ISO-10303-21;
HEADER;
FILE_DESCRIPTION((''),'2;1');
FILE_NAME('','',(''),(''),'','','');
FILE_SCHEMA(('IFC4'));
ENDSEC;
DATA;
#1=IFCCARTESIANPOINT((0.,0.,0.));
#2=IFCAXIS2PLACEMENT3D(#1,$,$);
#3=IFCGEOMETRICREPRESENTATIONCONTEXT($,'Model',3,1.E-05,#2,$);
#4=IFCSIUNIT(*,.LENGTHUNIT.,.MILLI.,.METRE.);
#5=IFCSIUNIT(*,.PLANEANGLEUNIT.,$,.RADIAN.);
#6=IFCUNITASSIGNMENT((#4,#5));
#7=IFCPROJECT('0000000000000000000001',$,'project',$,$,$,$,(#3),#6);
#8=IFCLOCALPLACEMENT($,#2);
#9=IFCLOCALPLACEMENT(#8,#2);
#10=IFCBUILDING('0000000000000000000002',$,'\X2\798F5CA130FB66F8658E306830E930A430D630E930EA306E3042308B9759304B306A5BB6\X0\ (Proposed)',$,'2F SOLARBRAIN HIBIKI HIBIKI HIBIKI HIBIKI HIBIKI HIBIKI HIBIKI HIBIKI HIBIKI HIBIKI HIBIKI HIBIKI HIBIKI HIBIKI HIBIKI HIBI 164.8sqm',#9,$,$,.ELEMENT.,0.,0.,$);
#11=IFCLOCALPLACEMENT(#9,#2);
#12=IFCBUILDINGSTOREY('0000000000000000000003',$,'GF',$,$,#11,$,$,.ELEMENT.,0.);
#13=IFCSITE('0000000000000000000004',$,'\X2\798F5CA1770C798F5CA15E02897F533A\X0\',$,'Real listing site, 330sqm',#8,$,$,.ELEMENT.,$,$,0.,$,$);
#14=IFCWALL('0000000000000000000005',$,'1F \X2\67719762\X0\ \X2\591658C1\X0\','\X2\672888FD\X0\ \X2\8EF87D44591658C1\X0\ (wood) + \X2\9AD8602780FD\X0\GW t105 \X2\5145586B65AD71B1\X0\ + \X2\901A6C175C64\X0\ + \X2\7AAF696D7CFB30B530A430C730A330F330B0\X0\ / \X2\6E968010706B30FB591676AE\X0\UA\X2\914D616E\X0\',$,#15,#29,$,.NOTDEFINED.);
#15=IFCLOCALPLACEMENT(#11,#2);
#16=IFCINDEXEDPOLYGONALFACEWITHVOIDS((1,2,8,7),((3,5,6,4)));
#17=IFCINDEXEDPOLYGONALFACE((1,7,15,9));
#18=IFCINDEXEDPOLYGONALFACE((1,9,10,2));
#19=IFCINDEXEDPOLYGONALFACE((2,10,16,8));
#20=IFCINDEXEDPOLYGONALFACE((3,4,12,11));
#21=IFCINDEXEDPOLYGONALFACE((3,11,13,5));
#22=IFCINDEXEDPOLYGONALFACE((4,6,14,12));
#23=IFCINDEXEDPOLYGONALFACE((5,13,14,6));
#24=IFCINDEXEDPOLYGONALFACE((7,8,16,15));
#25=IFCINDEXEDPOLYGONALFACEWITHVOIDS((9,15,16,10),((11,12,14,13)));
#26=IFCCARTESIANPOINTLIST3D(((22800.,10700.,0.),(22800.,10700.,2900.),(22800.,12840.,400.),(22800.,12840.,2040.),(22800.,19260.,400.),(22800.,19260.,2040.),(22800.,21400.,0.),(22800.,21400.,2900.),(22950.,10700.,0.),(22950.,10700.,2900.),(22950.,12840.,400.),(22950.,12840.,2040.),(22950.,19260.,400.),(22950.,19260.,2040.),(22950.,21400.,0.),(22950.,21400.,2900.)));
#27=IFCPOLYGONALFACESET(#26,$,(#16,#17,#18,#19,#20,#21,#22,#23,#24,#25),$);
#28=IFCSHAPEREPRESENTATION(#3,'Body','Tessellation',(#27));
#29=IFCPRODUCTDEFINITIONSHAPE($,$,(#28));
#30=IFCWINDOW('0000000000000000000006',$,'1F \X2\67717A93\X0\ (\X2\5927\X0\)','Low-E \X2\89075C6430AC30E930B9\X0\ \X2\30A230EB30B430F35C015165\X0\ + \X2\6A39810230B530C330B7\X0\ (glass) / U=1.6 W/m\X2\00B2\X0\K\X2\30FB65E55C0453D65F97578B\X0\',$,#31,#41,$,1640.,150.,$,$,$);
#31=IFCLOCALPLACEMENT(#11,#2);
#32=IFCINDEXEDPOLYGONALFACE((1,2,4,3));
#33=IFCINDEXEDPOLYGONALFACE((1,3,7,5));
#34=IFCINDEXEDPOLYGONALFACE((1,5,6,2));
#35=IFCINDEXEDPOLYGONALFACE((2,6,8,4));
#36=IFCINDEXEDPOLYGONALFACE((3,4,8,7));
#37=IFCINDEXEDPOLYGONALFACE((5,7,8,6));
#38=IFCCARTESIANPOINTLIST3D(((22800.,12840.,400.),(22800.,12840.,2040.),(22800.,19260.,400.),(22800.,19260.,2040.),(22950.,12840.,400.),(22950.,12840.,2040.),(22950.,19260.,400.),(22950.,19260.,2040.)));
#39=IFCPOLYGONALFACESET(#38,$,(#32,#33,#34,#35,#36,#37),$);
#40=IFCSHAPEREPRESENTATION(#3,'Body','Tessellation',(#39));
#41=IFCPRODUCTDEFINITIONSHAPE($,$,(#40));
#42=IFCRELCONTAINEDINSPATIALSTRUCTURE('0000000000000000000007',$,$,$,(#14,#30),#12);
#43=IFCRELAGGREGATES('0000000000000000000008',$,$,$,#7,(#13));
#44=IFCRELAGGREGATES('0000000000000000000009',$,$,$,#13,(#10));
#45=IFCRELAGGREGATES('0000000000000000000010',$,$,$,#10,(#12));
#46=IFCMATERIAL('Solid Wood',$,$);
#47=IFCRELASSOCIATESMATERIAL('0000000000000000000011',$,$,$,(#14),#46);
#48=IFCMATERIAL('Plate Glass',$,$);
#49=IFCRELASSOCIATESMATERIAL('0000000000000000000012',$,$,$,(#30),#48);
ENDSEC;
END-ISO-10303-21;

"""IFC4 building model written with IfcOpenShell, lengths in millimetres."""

from ifc_helpers import new_model, si_unit, frame, frame_2d, origin, place, context, project, spatial, rectangle, extrude, material, element, fill, save


model = new_model("IFC4")

# Units and contexts
model_context = context("Model", 3, precision=1e-05, world=origin())
ifc_project = project(units=[si_unit("LENGTHUNIT", "METRE", prefix="MILLI"), si_unit("PLANEANGLEUNIT", "RADIAN")], contexts=[model_context])

# Site, building, storey
site_placement = place(None, origin())
site = spatial("IfcSite", under=ifc_project, at=site_placement, Name="福岡県福岡市西区", ObjectType="Real listing site, 330sqm", CompositionType="ELEMENT", RefElevation=0.0)
building_placement = place(site_placement, origin())
building = spatial("IfcBuilding", under=site, at=building_placement, Name="福岡・書斎とライブラリのある静かな家 (Proposed)", ObjectType="2F SOLARBRAIN HIBIKI HIBIKI HIBIKI HIBIKI HIBIKI HIBIKI HIBIKI HIBIKI HIBIKI HIBIKI HIBIKI HIBIKI HIBIKI HIBIKI HIBIKI HIBI 164.8sqm", CompositionType="ELEMENT", ElevationOfRefHeight=0.0, ElevationOfTerrain=0.0)
storey_placement = place(building_placement, origin())
storey = spatial("IfcBuildingStorey", under=building, at=storey_placement, Name="GF", CompositionType="ELEMENT", Elevation=0.0)

# Shared definitions
ifc_material_1 = material(Name="Solid Wood")

# Wall, opening, window
wall_1_placement = place(storey_placement, frame((11400.0, 5350.0, 0.0)))
wall_1 = element("IfcWall", 1, at=wall_1_placement, inside=storey, material=ifc_material_1, Name="1F 東面 外壁", Description="木製 軸組外壁 (wood) + 高性能GW t105 充填断熱 + 通気層 + 窯業系サイディング / 準耐火・外皮UA配慮", PredefinedType="NOTDEFINED", context=model_context, shape_type="SweptSolid", body=[
    extrude(rectangle(XDim=150.0, YDim=10700.0, at=frame_2d((75.0, 5350.0))), frame((11400.0, 5350.0, 0.0)), (0.0, 0.0, 1.0), 2900.0),
])
opening_1_placement = place(storey_placement, frame((11400.0, 6420.0, 200.0)))
opening_1 = element("IfcOpeningElement", 2, at=opening_1_placement, cuts=wall_1, PredefinedType="NOTDEFINED", context=model_context, shape_type="SweptSolid", body=[
    extrude(rectangle(XDim=150.0, YDim=6420.0, at=frame_2d((75.0, 3210.0))), frame((11400.0, 6420.0, 200.0)), (0.0, 0.0, 1.0), 1640.0),
])
ifc_material_2 = material(Name="Plate Glass")
window_1_placement = place(storey_placement, frame((11400.0, 6420.0, 200.0)))
window_1 = element("IfcWindow", 3, at=window_1_placement, inside=storey, material=ifc_material_2, Name="1F 東窓 (大)", Description="Low-E 複層ガラス アルゴン封入 + 樹脂サッシ (glass) / U=1.6 W/m²K・日射取得型", OverallHeight=1640.0, OverallWidth=150.0, context=model_context, shape_type="SweptSolid", body=[
    extrude(rectangle(XDim=150.0, YDim=6420.0, at=frame_2d((75.0, 3210.0))), frame((11400.0, 6420.0, 200.0)), (0.0, 0.0, 1.0), 1640.0),
])
fill(opening_1, window_1)

save(model, "model.ifc")
